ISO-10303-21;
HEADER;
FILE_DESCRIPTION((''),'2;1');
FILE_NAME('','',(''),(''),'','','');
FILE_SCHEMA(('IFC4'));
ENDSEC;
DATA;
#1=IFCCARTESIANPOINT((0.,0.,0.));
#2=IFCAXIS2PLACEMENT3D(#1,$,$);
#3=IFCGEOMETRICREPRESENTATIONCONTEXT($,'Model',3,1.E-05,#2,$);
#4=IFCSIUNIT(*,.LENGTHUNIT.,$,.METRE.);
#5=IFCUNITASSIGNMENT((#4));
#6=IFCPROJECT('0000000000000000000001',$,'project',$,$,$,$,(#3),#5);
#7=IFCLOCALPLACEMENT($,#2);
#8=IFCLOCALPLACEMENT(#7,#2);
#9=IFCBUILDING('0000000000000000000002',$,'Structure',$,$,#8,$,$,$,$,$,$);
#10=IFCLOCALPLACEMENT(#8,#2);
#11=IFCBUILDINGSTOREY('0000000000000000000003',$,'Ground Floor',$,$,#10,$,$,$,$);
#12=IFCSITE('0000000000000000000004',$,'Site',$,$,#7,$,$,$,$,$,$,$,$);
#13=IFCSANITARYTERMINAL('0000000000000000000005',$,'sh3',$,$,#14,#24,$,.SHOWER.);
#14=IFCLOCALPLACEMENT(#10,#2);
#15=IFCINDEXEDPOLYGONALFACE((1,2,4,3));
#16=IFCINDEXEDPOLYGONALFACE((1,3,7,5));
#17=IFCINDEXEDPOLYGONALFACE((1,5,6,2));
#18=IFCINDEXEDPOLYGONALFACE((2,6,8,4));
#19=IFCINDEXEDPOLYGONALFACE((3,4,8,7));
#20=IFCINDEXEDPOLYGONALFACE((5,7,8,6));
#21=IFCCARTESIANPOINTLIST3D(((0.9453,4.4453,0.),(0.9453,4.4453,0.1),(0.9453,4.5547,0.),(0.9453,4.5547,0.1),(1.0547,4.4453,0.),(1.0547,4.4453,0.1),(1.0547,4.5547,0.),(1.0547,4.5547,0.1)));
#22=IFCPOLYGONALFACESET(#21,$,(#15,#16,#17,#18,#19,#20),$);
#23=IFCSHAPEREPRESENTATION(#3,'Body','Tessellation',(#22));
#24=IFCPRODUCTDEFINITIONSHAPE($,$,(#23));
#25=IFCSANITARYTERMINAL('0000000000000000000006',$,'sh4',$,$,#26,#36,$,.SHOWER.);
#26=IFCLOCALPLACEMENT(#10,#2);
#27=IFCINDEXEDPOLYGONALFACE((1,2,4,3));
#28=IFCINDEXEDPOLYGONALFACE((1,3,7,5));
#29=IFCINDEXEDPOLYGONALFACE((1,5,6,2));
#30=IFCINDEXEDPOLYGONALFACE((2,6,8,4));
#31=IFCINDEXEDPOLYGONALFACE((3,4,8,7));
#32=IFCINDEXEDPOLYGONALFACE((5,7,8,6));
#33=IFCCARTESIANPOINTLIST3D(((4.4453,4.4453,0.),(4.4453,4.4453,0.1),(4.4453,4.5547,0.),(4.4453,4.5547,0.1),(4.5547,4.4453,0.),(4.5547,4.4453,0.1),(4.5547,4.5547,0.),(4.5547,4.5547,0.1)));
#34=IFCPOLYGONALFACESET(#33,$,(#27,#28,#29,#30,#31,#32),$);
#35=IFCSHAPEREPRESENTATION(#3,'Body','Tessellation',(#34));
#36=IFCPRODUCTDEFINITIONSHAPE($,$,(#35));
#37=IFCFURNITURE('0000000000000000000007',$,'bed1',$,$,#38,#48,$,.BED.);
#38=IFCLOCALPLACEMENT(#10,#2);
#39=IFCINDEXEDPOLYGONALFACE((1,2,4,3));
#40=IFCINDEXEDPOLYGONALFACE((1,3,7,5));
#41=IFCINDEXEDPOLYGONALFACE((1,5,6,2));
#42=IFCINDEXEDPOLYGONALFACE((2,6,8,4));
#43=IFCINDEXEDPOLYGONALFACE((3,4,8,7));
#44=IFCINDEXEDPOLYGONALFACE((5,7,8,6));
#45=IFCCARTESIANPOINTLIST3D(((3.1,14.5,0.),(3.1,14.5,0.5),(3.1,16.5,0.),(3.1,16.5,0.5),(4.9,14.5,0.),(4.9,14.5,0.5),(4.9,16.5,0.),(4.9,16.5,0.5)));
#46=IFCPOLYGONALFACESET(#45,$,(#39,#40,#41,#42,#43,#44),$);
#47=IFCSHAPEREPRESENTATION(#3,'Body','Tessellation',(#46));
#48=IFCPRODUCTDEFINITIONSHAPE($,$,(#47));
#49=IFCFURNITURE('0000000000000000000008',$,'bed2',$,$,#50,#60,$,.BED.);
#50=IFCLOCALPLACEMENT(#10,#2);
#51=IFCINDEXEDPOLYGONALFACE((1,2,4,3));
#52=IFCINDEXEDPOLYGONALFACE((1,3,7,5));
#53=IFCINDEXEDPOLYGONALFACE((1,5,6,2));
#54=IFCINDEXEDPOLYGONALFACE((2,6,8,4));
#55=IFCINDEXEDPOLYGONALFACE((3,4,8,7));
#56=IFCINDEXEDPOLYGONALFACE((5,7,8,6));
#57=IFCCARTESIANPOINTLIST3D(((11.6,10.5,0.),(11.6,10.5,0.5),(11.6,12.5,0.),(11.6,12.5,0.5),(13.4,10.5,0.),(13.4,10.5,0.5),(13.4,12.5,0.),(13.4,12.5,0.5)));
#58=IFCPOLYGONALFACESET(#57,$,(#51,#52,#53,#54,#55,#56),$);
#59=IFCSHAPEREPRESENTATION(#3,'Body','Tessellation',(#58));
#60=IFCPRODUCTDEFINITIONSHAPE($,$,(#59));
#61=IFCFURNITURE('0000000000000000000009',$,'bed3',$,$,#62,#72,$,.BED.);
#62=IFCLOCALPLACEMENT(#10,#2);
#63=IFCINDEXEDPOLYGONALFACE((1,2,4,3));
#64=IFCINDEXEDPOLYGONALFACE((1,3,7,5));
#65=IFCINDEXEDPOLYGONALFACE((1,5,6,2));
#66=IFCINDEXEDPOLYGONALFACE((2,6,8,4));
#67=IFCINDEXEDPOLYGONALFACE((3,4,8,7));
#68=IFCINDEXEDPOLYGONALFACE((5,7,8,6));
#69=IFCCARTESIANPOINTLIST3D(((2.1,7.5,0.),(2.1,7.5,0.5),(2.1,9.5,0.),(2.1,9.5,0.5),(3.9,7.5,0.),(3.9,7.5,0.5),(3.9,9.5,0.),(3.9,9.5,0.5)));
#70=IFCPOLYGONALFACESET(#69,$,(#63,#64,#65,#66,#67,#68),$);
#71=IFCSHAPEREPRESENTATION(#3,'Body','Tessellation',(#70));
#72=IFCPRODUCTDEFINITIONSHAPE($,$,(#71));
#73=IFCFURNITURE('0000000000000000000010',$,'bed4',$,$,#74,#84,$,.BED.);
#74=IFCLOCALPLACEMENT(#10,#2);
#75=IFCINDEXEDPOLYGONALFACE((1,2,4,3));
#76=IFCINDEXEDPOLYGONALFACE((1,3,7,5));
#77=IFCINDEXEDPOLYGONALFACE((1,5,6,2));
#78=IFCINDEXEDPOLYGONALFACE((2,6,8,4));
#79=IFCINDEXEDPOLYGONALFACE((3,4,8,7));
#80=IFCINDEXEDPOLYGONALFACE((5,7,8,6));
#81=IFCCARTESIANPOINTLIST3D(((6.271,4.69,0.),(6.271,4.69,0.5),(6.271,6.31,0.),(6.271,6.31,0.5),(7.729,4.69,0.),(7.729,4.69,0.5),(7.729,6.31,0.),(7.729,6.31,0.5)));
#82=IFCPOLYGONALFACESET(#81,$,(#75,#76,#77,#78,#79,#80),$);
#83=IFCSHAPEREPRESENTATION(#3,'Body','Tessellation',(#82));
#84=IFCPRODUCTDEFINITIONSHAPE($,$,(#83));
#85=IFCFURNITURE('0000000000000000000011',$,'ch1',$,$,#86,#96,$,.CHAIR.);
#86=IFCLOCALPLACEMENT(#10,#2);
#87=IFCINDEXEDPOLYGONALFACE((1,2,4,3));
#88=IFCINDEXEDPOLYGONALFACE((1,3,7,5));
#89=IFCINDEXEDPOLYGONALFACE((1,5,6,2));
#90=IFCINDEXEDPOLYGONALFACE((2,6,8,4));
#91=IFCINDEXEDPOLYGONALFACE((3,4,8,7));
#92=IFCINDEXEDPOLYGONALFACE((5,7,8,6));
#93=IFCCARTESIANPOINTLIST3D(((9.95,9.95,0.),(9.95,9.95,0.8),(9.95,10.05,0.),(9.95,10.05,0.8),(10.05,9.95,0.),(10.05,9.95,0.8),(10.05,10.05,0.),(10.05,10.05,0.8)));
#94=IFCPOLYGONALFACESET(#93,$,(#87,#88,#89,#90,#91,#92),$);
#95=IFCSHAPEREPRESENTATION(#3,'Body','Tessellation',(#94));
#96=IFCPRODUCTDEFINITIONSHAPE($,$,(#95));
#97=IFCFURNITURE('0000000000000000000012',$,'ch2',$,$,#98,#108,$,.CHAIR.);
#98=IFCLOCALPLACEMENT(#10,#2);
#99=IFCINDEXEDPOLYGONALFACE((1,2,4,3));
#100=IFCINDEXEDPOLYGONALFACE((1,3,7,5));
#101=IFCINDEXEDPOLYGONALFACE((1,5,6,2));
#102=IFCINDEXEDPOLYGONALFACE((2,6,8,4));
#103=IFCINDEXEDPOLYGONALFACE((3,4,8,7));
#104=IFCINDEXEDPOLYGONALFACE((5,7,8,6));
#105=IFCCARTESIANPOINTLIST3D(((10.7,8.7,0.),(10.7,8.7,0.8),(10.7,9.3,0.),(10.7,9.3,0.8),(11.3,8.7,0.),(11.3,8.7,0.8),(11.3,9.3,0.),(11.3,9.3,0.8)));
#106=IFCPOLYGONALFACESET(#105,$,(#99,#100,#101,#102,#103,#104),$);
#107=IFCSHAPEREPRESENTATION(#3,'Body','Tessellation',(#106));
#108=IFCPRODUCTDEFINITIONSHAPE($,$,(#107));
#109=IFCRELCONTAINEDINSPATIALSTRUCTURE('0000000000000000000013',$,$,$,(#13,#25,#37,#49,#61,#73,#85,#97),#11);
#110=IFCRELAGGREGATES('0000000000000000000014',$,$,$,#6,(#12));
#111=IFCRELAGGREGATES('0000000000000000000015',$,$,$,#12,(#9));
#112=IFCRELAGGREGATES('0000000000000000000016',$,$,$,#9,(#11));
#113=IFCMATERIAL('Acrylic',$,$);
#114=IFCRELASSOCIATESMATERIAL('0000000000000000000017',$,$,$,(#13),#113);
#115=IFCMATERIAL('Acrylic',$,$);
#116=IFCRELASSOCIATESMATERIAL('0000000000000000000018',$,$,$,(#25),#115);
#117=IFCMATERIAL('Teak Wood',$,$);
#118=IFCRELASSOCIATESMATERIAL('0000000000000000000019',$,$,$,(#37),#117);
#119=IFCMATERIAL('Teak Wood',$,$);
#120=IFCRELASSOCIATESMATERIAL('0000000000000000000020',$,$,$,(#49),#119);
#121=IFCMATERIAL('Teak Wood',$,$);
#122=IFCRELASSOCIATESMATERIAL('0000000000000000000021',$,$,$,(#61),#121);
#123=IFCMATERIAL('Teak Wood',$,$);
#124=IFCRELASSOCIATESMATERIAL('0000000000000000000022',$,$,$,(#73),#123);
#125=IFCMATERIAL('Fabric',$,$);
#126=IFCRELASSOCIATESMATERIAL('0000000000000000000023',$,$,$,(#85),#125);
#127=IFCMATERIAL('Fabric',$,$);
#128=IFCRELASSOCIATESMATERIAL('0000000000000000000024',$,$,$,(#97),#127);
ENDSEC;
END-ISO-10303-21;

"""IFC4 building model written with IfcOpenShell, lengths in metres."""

from ifc_helpers import new_model, si_unit, frame, origin, place, context, project, spatial, polyline, outline, extrude, material, element, save


model = new_model("IFC4")

# Units and contexts
model_context = context("Model", 3, precision=1e-05, world=origin())
ifc_project = project(units=[si_unit("LENGTHUNIT", "METRE")], contexts=[model_context])

# Site, building, storey
site_placement = place(None, origin())
site = spatial("IfcSite", under=ifc_project, at=site_placement, Name="Site")
building_placement = place(site_placement, origin())
building = spatial("IfcBuilding", under=site, at=building_placement, Name="Structure")
storey_placement = place(building_placement, origin())
storey = spatial("IfcBuildingStorey", under=building, at=storey_placement, Name="Ground Floor")

# Sanitary terminals
ifc_material_1 = material(Name="Acrylic")
sanitary_terminal_1_placement = place(storey_placement, frame((1.0, 4.5, 0.0)))
element("IfcSanitaryTerminal", 1, at=sanitary_terminal_1_placement, inside=storey, material=ifc_material_1, Name="sh3", PredefinedType="SHOWER", context=model_context, shape_type="SweptSolid", body=[
    extrude(outline(polyline([(-0.0547, -0.0547), (0.0547, -0.0547), (0.0547, 0.0547), (-0.0547, 0.0547), (-0.0547, -0.0547)])), origin(), (0.0, 0.0, 1.0), 0.1),
])
ifc_material_2 = material(Name="Acrylic")
sanitary_terminal_2_placement = place(storey_placement, frame((4.5, 4.5, 0.0)))
element("IfcSanitaryTerminal", 2, at=sanitary_terminal_2_placement, inside=storey, material=ifc_material_2, Name="sh4", PredefinedType="SHOWER", context=model_context, shape_type="SweptSolid", body=[
    extrude(outline(polyline([(-0.0547, -0.0547), (0.0547, -0.0547), (0.0547, 0.0547), (-0.0547, 0.0547), (-0.0547, -0.0547)])), origin(), (0.0, 0.0, 1.0), 0.1),
])

# Furniture
ifc_material_3 = material(Name="Teak Wood")
furniture_1_placement = place(storey_placement, frame((4.0, 15.5, 0.0)))
element("IfcFurniture", 3, at=furniture_1_placement, inside=storey, material=ifc_material_3, Name="bed1", PredefinedType="BED", context=model_context, shape_type="SweptSolid", body=[
    extrude(outline(polyline([(-0.9, -1.0), (0.9, -1.0), (0.9, 1.0), (-0.9, 1.0), (-0.9, -1.0)])), origin(), (0.0, 0.0, 1.0), 0.5),
])
ifc_material_4 = material(Name="Teak Wood")
furniture_2_placement = place(storey_placement, frame((12.5, 11.5, 0.0)))
element("IfcFurniture", 4, at=furniture_2_placement, inside=storey, material=ifc_material_4, Name="bed2", PredefinedType="BED", context=model_context, shape_type="SweptSolid", body=[
    extrude(outline(polyline([(-0.9, -1.0), (0.9, -1.0), (0.9, 1.0), (-0.9, 1.0), (-0.9, -1.0)])), origin(), (0.0, 0.0, 1.0), 0.5),
])
ifc_material_5 = material(Name="Teak Wood")
furniture_3_placement = place(storey_placement, frame((3.0, 8.5, 0.0)))
element("IfcFurniture", 5, at=furniture_3_placement, inside=storey, material=ifc_material_5, Name="bed3", PredefinedType="BED", context=model_context, shape_type="SweptSolid", body=[
    extrude(outline(polyline([(-0.9, -1.0), (0.9, -1.0), (0.9, 1.0), (-0.9, 1.0), (-0.9, -1.0)])), origin(), (0.0, 0.0, 1.0), 0.5),
])
ifc_material_6 = material(Name="Teak Wood")
furniture_4_placement = place(storey_placement, frame((7.0, 5.5, 0.0)))
element("IfcFurniture", 6, at=furniture_4_placement, inside=storey, material=ifc_material_6, Name="bed4", PredefinedType="BED", context=model_context, shape_type="SweptSolid", body=[
    extrude(outline(polyline([(-0.729, -0.81), (0.729, -0.81), (0.729, 0.81), (-0.729, 0.81), (-0.729, -0.81)])), origin(), (0.0, 0.0, 1.0), 0.5),
])
ifc_material_7 = material(Name="Fabric")
furniture_5_placement = place(storey_placement, frame((10.0, 10.0, 0.0)))
element("IfcFurniture", 7, at=furniture_5_placement, inside=storey, material=ifc_material_7, Name="ch1", PredefinedType="CHAIR", context=model_context, shape_type="SweptSolid", body=[
    extrude(outline(polyline([(-0.05, -0.05), (0.05, -0.05), (0.05, 0.05), (-0.05, 0.05), (-0.05, -0.05)])), origin(), (0.0, 0.0, 1.0), 0.8),
])
ifc_material_8 = material(Name="Fabric")
furniture_6_placement = place(storey_placement, frame((11.0, 9.0, 0.0)))
element("IfcFurniture", 8, at=furniture_6_placement, inside=storey, material=ifc_material_8, Name="ch2", PredefinedType="CHAIR", context=model_context, shape_type="SweptSolid", body=[
    extrude(outline(polyline([(-0.3, -0.3), (0.3, -0.3), (0.3, 0.3), (-0.3, 0.3), (-0.3, -0.3)])), origin(), (0.0, 0.0, 1.0), 0.8),
])

save(model, "model.ifc")
